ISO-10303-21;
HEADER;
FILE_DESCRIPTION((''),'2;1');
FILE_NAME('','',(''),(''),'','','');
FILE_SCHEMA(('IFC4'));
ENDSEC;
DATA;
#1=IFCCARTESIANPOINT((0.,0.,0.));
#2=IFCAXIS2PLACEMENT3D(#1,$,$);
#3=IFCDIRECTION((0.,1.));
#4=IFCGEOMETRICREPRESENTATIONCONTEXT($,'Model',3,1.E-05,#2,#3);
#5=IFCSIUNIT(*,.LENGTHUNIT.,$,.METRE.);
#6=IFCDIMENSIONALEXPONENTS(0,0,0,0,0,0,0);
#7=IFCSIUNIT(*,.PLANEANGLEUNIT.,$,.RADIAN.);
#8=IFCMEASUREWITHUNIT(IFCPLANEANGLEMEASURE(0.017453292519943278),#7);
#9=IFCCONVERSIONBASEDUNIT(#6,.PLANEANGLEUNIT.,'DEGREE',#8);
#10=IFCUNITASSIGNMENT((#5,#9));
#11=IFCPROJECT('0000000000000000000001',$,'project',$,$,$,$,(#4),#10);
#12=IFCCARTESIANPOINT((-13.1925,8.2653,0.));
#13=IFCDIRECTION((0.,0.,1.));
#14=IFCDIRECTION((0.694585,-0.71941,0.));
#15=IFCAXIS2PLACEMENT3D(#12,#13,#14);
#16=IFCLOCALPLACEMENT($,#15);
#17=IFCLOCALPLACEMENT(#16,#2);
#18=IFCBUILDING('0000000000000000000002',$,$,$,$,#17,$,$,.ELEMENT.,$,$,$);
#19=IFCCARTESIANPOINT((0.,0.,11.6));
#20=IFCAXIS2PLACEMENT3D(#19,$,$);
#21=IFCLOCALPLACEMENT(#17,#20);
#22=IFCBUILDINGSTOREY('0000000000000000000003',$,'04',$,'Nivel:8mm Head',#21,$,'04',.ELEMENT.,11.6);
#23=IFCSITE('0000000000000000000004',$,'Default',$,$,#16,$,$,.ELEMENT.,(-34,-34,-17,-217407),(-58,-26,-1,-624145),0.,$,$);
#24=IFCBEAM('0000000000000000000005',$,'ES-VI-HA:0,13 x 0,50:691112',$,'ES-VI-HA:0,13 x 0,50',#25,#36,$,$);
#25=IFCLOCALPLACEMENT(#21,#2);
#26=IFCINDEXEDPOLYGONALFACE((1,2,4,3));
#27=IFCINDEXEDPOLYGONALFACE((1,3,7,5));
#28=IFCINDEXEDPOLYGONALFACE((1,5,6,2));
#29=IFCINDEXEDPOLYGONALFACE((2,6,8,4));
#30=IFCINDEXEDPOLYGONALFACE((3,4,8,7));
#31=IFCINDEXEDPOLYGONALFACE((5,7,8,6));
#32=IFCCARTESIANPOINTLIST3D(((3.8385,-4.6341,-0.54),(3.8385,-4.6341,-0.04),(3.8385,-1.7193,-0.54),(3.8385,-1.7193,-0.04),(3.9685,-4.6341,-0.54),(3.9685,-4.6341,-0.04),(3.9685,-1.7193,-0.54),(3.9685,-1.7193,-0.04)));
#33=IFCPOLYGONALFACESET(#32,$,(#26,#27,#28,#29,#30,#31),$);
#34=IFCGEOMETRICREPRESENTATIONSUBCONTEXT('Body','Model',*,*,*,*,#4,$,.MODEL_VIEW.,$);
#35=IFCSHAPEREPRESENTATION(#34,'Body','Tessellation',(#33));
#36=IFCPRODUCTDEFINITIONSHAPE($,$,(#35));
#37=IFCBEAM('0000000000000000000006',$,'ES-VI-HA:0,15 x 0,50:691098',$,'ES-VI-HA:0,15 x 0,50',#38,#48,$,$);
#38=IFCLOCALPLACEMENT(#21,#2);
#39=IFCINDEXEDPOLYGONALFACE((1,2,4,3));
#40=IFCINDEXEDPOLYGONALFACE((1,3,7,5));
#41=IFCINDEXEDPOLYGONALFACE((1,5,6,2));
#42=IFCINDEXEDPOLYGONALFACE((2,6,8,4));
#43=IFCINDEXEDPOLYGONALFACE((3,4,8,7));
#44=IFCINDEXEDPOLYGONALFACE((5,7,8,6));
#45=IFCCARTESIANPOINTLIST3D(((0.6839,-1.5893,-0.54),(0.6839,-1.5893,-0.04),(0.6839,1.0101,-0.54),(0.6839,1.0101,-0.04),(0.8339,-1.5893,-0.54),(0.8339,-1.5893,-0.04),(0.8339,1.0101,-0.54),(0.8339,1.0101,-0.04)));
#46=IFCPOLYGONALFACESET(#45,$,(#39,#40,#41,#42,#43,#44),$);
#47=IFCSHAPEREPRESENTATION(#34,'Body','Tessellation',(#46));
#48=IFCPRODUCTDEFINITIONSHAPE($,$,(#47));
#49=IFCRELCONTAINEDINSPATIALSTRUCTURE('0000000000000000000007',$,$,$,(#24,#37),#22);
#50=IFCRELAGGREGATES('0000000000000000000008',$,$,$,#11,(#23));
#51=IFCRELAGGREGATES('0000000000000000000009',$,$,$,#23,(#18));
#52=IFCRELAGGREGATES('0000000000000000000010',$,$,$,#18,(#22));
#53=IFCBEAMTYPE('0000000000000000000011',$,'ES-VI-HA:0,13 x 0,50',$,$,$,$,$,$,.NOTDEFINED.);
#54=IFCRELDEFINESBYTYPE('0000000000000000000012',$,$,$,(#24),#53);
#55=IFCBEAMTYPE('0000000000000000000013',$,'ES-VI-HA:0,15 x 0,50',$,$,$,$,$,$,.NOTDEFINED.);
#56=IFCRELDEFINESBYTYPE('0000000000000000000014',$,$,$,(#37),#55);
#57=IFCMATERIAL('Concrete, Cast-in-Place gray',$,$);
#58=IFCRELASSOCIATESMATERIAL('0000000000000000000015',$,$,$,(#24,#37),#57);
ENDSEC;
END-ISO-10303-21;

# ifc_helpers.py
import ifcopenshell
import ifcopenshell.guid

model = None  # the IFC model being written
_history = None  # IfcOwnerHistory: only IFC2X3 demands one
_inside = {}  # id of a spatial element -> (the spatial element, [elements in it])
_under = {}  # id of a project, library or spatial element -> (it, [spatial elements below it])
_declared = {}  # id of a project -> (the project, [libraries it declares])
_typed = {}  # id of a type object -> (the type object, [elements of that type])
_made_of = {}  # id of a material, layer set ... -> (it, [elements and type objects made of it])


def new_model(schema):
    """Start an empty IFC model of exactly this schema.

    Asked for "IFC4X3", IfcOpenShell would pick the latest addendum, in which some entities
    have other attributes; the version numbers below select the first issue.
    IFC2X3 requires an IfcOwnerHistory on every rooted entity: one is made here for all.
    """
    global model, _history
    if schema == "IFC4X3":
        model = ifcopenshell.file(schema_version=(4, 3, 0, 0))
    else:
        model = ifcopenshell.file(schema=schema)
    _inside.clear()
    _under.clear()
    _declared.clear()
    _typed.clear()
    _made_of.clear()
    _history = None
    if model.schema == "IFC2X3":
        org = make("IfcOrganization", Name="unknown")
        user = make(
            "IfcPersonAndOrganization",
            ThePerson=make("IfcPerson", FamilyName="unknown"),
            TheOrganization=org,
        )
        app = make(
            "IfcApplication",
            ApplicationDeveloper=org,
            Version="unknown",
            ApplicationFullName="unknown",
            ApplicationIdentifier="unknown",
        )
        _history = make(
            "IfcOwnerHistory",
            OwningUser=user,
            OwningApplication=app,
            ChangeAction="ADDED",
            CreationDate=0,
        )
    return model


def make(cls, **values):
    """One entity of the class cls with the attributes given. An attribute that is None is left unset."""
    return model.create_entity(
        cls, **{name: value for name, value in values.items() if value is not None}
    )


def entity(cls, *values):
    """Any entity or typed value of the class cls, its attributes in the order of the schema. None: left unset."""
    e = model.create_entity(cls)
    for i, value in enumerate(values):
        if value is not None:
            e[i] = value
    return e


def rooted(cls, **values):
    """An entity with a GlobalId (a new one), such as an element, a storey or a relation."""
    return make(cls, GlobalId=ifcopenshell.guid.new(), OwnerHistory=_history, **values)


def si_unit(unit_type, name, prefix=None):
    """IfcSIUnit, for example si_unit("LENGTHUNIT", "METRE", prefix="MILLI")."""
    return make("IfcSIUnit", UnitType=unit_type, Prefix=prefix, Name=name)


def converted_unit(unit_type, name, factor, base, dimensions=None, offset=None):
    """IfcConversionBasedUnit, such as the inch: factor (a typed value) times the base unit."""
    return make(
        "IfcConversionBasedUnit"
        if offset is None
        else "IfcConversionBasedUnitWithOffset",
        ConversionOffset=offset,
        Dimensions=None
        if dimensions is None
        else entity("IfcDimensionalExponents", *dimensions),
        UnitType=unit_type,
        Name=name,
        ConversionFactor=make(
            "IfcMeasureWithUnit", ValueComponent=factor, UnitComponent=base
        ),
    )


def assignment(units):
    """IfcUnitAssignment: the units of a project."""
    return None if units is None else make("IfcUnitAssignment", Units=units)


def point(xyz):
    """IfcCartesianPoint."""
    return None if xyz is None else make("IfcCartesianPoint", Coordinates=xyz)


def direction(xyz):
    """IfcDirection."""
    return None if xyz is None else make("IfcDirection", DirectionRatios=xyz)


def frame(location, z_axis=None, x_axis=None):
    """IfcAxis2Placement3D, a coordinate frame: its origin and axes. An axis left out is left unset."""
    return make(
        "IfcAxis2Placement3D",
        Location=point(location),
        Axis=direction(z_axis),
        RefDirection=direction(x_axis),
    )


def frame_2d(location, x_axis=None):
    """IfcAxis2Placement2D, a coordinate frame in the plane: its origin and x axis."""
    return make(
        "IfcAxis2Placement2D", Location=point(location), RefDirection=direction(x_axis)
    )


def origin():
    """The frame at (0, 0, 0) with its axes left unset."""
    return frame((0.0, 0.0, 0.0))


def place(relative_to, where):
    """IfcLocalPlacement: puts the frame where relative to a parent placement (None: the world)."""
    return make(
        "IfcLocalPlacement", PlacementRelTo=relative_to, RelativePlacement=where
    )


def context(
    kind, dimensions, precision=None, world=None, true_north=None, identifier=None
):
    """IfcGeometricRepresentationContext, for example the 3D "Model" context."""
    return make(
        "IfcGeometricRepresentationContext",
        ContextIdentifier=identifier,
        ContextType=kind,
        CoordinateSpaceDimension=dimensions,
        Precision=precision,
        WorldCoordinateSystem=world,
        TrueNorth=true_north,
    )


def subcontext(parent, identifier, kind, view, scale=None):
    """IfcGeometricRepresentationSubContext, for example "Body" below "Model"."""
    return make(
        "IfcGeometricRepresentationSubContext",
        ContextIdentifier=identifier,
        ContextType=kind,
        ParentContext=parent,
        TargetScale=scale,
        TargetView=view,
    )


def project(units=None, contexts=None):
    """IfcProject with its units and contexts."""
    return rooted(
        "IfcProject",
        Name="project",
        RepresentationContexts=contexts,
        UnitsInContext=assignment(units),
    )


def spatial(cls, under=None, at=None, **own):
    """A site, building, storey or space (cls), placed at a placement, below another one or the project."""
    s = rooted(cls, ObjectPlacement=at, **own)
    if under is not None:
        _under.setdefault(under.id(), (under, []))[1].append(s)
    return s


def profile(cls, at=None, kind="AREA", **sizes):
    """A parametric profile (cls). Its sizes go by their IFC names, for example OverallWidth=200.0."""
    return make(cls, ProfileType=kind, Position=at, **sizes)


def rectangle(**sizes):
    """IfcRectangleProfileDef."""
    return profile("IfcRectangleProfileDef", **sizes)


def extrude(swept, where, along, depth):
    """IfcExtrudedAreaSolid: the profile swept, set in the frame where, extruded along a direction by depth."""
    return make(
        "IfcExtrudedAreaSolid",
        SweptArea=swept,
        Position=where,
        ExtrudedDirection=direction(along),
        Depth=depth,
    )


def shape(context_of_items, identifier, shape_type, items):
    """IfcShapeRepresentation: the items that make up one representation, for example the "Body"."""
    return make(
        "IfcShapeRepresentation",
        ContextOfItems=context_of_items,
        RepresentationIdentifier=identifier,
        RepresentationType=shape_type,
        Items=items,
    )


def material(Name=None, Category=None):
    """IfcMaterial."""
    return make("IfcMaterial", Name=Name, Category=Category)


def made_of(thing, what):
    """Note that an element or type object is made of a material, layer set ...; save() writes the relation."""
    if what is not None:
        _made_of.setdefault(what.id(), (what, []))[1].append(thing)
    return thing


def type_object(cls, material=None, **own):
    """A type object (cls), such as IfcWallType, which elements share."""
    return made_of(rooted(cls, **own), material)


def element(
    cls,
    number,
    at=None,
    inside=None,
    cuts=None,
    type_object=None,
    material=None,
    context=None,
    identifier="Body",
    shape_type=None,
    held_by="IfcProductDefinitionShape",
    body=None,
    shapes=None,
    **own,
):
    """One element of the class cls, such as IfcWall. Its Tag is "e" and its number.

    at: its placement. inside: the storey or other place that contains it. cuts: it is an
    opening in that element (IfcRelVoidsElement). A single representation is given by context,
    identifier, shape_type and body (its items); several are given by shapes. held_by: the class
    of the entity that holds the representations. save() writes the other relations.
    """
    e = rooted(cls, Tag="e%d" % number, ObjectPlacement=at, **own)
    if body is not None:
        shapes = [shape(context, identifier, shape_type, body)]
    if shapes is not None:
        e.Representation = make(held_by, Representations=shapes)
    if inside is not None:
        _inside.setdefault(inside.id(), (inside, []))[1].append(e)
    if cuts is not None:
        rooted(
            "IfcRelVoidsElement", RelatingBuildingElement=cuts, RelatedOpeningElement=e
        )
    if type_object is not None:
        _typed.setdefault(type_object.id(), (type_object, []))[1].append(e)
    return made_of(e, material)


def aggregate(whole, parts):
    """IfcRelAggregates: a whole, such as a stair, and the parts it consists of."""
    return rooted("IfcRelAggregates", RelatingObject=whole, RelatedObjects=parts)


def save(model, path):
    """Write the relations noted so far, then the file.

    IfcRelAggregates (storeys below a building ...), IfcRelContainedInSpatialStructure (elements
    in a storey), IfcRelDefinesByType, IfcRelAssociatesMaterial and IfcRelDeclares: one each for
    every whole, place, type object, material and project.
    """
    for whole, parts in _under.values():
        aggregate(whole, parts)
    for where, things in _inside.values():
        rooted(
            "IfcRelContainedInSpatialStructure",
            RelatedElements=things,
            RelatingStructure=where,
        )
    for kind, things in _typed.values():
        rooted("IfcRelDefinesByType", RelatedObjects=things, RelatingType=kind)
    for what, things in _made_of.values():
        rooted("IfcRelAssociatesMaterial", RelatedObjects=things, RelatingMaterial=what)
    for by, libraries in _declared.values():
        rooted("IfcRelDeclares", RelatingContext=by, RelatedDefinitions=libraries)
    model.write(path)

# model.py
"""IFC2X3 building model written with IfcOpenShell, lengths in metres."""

from ifc_helpers import new_model, entity, si_unit, converted_unit, direction, frame, frame_2d, origin, place, context, subcontext, project, spatial, rectangle, extrude, material, type_object, element, save


model = new_model("IFC2X3")

# Units and contexts
model_context = context("Model", 3, precision=1e-05, world=origin(), true_north=direction((0.0, 1.0)))
body_context = subcontext(model_context, "Body", "Model", "MODEL_VIEW")
ifc_project = project(units=[si_unit("LENGTHUNIT", "METRE"), converted_unit("PLANEANGLEUNIT", "DEGREE", entity("IfcPlaneAngleMeasure", 0.017453292519943278), si_unit("PLANEANGLEUNIT", "RADIAN"), dimensions=[0, 0, 0, 0, 0, 0, 0])], contexts=[model_context])

# Site, building, storey
site_placement = place(None, frame((-13.1925, 8.2653, 0.0), z_axis=(0.0, 0.0, 1.0), x_axis=(0.694585, -0.71941, 0.0)))
site = spatial("IfcSite", under=ifc_project, at=site_placement, Name="Default", CompositionType="ELEMENT", RefLatitude=(-34, -34, -17, -217407), RefLongitude=(-58, -26, -1, -624145), RefElevation=0.0)
building_placement = place(site_placement, origin())
building = spatial("IfcBuilding", under=site, at=building_placement, CompositionType="ELEMENT")
storey_placement = place(building_placement, frame((0.0, 0.0, 11.6)))
storey = spatial("IfcBuildingStorey", under=building, at=storey_placement, Name="04", ObjectType="Nivel:8mm Head", LongName="04", CompositionType="ELEMENT", Elevation=11.6)

# Beams
ifc_material_1 = material(Name="Concrete, Cast-in-Place gray")
beam_type_1 = type_object("IfcBeamType", Name="ES-VI-HA:0,13 x 0,50", PredefinedType="NOTDEFINED")
beam_1_placement = place(storey_placement, frame((3.9035, -4.7011, -0.04), z_axis=(0.0, 0.0, 1.0), x_axis=(0.0, 1.0, 0.0)))
element("IfcBeam", 1, at=beam_1_placement, inside=storey, type_object=beam_type_1, material=ifc_material_1, Name="ES-VI-HA:0,13 x 0,50:691112", ObjectType="ES-VI-HA:0,13 x 0,50", context=body_context, shape_type="SweptSolid", body=[
    extrude(rectangle(XDim=0.5, YDim=0.13, at=frame_2d((0.0, 0.0), x_axis=(1.0, 0.0))), frame((0.067, 0.0, -0.25), z_axis=(1.0, 0.0, 0.0), x_axis=(0.0, 0.0, -1.0)), (0.0, 0.0, 1.0), 2.9148),
])
beam_type_2 = type_object("IfcBeamType", Name="ES-VI-HA:0,15 x 0,50", PredefinedType="NOTDEFINED")
beam_2_placement = place(storey_placement, frame((0.7589, -1.6543, -0.04), z_axis=(0.0, 0.0, 1.0), x_axis=(0.0, 1.0, 0.0)))
element("IfcBeam", 2, at=beam_2_placement, inside=storey, type_object=beam_type_2, material=ifc_material_1, Name="ES-VI-HA:0,15 x 0,50:691098", ObjectType="ES-VI-HA:0,15 x 0,50", context=body_context, shape_type="SweptSolid", body=[
    extrude(rectangle(XDim=0.5, YDim=0.15, at=frame_2d((0.0, 0.0), x_axis=(1.0, 0.0))), frame((0.065, 0.0, -0.25), z_axis=(1.0, 0.0, 0.0), x_axis=(0.0, 0.0, -1.0)), (0.0, 0.0, 1.0), 2.5994),
])

save(model, "model.ifc")
